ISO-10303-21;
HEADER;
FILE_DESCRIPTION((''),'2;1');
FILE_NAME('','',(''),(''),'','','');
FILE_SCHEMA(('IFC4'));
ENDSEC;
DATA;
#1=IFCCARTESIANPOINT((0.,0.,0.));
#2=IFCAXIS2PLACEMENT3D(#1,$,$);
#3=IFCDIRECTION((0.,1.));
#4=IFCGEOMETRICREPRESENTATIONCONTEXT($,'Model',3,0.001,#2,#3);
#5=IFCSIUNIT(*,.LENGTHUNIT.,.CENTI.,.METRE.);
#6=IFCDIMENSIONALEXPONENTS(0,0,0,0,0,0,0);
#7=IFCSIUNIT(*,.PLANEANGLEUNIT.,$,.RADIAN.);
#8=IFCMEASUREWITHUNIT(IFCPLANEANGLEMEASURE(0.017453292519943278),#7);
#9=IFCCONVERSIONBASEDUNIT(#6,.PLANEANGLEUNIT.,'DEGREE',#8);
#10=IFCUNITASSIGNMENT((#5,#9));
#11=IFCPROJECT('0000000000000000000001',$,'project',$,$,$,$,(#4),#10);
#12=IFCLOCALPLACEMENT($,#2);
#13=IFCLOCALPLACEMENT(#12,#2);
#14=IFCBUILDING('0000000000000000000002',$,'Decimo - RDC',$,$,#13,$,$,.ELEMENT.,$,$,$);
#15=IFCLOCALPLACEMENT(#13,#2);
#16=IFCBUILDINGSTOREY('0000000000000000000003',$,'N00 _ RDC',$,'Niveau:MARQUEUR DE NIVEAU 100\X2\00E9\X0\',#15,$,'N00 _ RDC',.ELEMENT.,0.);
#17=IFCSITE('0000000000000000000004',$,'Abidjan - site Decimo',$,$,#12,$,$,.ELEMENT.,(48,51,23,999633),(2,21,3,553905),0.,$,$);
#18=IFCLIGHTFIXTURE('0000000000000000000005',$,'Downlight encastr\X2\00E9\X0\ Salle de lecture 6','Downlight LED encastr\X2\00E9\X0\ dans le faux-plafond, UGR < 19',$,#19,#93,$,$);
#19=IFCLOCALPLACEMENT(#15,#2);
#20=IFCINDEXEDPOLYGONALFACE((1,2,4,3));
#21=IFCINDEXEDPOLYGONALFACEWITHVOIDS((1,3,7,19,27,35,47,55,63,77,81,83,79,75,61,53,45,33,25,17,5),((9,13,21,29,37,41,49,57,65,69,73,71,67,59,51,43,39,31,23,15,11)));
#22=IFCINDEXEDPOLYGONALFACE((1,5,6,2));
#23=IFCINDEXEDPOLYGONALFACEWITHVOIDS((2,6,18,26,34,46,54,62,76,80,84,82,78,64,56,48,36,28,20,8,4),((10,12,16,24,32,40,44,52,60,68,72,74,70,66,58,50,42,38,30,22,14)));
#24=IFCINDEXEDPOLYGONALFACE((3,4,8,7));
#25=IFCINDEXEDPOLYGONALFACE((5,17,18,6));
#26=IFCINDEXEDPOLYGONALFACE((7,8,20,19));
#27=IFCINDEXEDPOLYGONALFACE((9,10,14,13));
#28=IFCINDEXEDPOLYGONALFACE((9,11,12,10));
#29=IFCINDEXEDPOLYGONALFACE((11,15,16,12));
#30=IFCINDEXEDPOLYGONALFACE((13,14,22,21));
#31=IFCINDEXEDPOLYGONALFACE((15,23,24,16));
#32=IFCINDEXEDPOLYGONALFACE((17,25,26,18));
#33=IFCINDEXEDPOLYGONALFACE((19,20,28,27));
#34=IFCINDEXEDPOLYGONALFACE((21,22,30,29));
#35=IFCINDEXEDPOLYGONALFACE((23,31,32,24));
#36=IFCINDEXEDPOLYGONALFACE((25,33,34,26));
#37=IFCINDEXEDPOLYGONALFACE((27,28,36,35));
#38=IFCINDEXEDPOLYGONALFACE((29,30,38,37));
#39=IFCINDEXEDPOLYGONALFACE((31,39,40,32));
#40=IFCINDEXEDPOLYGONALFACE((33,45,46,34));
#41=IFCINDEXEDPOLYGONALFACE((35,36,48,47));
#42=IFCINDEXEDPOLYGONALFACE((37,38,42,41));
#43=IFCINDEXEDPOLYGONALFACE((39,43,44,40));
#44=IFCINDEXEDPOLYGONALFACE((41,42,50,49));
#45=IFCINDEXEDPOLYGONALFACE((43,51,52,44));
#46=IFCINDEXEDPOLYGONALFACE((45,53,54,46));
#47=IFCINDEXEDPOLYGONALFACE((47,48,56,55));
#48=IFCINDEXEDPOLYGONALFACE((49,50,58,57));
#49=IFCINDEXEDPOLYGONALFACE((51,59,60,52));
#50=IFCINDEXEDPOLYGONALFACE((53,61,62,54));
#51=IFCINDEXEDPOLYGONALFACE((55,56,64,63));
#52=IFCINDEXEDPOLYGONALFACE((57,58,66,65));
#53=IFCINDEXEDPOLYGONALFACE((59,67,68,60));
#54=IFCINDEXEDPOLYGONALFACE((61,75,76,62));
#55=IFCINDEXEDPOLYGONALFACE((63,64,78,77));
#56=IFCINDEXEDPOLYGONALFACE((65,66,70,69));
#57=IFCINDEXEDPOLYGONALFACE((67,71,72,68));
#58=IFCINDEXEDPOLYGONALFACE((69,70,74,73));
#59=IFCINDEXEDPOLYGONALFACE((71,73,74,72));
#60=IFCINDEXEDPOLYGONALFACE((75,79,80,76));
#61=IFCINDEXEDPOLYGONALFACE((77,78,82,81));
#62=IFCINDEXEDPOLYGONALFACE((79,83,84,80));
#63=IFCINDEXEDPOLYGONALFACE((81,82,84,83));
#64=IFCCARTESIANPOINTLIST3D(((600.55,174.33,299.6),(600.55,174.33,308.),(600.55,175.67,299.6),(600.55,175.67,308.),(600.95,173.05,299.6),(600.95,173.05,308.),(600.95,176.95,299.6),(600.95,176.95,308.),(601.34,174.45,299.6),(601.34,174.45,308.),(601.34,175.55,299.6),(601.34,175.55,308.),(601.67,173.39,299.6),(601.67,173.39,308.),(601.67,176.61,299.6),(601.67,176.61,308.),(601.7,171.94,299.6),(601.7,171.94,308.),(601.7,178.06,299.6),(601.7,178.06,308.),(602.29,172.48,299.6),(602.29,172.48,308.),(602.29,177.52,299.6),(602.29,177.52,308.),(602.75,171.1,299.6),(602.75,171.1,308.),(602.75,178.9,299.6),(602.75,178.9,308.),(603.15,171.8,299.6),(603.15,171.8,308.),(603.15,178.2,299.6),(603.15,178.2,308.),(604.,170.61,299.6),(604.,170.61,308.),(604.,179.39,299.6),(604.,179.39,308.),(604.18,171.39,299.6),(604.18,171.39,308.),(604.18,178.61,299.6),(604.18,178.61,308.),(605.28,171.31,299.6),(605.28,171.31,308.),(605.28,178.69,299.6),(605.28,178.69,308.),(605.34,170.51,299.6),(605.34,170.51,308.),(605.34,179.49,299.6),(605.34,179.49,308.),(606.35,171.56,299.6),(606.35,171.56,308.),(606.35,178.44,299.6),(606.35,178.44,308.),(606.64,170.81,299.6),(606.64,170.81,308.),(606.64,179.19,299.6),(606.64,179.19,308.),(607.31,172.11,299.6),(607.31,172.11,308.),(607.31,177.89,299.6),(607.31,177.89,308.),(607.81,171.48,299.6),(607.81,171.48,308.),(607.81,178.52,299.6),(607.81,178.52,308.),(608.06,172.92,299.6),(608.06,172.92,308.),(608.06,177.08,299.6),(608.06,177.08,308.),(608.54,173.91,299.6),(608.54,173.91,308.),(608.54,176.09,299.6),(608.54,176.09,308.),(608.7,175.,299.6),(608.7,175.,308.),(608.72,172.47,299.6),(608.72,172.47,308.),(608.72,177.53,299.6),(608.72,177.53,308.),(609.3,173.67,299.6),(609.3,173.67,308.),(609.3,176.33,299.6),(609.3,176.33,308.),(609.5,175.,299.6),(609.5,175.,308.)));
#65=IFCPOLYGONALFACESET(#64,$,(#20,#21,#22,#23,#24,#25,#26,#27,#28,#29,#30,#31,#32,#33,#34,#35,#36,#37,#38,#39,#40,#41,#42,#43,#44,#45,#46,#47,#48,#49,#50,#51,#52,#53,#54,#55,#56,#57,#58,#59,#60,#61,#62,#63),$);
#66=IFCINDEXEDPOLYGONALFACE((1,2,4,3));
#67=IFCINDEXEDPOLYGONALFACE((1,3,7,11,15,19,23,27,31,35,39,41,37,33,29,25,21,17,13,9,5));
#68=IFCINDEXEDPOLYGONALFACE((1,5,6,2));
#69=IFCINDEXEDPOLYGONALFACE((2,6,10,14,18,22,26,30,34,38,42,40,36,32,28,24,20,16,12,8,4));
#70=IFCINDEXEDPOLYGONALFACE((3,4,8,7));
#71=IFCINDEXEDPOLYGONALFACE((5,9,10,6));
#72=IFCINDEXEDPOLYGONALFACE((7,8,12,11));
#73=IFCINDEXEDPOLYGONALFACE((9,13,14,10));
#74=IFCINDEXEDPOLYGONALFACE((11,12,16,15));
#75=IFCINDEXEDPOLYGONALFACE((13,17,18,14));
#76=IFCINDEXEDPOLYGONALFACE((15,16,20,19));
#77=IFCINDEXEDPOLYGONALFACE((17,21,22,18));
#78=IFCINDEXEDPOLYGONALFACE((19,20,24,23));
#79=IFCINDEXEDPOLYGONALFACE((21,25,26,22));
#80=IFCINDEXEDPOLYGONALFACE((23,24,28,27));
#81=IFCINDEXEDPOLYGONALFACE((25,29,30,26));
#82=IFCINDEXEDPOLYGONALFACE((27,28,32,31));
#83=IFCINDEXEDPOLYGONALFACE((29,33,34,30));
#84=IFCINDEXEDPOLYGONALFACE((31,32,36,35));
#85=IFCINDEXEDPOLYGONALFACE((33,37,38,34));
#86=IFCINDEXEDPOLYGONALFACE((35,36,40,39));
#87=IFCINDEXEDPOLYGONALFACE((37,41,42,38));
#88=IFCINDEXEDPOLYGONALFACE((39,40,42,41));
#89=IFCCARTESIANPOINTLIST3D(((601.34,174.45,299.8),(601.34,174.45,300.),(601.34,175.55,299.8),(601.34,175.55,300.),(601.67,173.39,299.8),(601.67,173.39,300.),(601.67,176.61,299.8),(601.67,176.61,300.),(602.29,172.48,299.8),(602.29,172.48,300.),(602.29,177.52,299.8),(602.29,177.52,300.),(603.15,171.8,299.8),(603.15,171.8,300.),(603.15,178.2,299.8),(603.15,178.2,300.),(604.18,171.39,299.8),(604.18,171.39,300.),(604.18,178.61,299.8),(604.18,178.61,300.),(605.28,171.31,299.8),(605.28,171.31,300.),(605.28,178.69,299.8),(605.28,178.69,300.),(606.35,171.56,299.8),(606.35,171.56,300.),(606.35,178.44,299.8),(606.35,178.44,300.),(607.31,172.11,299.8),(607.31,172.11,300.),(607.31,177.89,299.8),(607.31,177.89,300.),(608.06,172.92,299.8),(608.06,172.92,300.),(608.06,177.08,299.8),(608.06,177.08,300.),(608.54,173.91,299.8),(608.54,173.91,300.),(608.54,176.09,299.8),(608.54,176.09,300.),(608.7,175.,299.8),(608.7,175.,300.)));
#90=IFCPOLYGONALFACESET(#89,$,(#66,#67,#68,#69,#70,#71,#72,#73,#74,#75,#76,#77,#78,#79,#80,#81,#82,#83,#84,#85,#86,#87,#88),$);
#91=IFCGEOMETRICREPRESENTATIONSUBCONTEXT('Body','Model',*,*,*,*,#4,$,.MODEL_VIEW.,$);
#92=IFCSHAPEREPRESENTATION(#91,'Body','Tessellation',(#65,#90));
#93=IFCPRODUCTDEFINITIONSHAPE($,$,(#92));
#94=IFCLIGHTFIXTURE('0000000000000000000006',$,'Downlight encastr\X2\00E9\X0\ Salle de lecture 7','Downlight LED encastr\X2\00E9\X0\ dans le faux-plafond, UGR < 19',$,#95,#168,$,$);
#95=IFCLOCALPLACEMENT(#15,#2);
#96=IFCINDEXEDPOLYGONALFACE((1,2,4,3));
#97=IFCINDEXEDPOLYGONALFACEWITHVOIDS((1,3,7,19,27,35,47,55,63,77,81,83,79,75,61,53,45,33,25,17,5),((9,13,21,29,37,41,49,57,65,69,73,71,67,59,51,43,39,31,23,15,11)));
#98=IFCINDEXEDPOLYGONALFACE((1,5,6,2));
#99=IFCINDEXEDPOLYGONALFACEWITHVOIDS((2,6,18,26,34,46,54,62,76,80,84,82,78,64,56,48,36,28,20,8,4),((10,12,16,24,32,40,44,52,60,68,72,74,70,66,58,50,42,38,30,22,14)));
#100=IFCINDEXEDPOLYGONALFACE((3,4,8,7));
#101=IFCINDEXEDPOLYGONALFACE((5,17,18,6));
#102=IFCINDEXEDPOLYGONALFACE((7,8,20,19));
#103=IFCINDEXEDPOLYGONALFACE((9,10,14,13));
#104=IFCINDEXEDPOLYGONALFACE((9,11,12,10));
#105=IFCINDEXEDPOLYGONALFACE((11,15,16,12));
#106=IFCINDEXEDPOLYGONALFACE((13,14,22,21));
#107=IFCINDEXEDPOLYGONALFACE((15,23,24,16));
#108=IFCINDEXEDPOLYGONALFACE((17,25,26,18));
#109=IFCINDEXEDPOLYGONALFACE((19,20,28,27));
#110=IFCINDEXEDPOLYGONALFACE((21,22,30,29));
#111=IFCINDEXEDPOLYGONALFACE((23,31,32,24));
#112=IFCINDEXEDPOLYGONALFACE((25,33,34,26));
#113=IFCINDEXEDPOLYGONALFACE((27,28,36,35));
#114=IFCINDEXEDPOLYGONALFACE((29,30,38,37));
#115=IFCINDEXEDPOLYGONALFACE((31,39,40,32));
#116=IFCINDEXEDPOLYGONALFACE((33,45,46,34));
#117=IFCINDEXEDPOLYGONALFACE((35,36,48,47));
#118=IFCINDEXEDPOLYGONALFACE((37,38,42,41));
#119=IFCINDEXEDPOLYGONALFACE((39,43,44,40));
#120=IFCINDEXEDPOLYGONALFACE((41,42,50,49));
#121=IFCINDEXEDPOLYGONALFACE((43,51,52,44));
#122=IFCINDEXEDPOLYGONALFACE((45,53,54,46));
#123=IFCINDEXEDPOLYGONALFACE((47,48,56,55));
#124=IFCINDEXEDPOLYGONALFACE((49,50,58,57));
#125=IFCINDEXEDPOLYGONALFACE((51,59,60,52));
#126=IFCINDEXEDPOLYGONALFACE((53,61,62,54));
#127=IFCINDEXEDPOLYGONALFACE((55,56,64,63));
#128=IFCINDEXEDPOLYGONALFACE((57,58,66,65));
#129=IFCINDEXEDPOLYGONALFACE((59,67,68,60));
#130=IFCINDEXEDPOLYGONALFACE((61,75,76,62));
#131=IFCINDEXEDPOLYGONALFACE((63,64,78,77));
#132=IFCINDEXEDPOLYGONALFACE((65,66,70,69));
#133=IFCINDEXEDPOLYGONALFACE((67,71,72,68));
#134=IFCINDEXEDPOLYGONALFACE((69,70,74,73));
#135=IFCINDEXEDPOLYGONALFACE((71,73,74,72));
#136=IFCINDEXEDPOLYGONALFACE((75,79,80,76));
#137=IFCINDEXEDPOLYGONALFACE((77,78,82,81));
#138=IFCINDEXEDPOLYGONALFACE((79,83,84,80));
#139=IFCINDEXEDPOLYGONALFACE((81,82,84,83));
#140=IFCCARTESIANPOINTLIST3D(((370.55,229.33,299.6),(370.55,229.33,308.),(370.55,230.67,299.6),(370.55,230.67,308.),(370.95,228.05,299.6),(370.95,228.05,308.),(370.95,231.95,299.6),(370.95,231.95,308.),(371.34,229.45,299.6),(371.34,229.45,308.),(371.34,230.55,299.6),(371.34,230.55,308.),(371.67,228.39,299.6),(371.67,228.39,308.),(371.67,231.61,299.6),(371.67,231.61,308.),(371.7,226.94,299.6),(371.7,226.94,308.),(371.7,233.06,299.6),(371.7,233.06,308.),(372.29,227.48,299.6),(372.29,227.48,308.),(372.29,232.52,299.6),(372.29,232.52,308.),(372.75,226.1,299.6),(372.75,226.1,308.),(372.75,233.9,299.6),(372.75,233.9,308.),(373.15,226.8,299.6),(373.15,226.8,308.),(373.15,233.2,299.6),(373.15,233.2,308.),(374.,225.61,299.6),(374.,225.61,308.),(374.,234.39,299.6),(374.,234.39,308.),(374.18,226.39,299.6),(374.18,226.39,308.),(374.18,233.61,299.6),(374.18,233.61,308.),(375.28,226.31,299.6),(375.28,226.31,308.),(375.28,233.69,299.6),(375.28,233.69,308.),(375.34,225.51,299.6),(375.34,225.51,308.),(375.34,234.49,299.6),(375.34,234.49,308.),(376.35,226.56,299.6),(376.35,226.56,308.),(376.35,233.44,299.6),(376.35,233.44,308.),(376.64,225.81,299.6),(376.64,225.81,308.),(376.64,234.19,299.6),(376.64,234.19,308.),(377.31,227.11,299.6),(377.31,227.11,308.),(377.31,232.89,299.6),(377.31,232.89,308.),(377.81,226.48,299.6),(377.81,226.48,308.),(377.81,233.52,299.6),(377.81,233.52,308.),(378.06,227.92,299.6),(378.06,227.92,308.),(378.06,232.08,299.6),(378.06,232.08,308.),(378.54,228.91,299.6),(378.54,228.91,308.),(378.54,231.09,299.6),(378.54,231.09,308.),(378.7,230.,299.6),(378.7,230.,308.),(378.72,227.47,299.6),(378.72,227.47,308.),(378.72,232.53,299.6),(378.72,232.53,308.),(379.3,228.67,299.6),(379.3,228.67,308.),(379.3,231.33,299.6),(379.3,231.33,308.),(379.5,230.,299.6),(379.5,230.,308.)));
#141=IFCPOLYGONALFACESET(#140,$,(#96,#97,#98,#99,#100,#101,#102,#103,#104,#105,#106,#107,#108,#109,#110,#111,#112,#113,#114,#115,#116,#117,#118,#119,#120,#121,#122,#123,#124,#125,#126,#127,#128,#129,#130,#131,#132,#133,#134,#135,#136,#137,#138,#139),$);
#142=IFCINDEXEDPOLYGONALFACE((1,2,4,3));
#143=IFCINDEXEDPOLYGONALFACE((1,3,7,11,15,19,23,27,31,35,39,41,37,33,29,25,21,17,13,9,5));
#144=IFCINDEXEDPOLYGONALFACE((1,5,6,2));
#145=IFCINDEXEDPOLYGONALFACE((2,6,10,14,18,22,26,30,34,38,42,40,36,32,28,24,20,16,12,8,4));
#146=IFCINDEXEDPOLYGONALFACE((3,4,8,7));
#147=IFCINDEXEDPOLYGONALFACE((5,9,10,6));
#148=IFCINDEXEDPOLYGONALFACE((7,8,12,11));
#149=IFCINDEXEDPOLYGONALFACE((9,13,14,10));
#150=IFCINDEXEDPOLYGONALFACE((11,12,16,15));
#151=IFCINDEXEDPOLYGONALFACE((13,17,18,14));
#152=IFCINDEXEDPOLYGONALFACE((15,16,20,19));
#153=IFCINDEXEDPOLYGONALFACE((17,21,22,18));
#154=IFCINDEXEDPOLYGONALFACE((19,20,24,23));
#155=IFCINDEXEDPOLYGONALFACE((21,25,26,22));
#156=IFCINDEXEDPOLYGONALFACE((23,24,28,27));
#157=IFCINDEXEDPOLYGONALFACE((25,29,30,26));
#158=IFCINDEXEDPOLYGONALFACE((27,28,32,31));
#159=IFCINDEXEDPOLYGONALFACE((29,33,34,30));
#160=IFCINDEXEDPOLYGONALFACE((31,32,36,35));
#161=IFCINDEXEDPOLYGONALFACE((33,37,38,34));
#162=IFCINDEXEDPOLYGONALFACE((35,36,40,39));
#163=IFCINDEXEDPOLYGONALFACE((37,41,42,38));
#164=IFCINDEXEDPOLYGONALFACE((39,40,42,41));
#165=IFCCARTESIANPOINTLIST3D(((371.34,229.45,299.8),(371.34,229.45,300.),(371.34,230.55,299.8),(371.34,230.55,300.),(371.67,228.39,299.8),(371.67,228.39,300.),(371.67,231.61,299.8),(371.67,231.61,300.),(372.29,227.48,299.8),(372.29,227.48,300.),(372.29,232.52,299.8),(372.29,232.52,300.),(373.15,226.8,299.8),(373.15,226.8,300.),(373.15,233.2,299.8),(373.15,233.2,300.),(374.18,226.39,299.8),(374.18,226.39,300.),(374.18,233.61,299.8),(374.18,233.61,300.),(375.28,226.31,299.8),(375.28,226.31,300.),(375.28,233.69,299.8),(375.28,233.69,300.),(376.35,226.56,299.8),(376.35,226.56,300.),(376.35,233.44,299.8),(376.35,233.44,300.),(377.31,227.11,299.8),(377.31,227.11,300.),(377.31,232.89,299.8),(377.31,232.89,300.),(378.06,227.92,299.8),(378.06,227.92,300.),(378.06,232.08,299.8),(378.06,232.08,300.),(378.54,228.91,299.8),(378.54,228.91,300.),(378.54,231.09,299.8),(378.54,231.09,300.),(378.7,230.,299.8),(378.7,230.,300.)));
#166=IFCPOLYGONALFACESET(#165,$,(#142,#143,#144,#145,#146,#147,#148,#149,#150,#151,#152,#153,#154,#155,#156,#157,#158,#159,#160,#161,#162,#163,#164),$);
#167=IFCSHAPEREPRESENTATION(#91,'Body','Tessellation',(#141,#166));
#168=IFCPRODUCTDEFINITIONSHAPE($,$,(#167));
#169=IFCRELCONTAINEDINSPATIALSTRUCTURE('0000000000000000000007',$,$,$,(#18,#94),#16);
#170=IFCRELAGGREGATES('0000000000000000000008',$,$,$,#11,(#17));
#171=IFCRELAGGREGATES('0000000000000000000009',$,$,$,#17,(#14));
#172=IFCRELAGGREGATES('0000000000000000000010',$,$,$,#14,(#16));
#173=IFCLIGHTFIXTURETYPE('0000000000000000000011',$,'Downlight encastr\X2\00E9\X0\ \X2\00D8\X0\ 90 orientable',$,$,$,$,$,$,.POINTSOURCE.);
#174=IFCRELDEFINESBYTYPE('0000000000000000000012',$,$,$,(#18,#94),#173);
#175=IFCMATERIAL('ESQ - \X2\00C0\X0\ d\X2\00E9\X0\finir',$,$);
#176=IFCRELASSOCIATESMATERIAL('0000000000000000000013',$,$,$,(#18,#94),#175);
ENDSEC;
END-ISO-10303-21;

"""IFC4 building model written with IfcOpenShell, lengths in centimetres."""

from ifc_helpers import new_model, entity, si_unit, converted_unit, direction, frame, frame_2d, origin, origin_with_axes, place, context, subcontext, project, spatial, circle, hollow_circle, extrude, material, type_object, element, save


model = new_model("IFC4")

# Units and contexts
model_context = context("Model", 3, precision=0.001, world=origin(), true_north=direction((0.0, 1.0)))
body_context = subcontext(model_context, "Body", "Model", "MODEL_VIEW")
ifc_project = project(units=[si_unit("LENGTHUNIT", "METRE", prefix="CENTI"), converted_unit("PLANEANGLEUNIT", "DEGREE", entity("IfcPlaneAngleMeasure", 0.017453292519943278), si_unit("PLANEANGLEUNIT", "RADIAN"), dimensions=[0, 0, 0, 0, 0, 0, 0])], contexts=[model_context])

# Site, building, storey
site_placement = place(None, origin())
site = spatial("IfcSite", under=ifc_project, at=site_placement, Name="Abidjan - site Decimo", CompositionType="ELEMENT", RefLatitude=(48, 51, 23, 999633), RefLongitude=(2, 21, 3, 553905), RefElevation=0.0)
building_placement = place(site_placement, origin())
building = spatial("IfcBuilding", under=site, at=building_placement, Name="Decimo - RDC", CompositionType="ELEMENT")
storey_placement = place(building_placement, origin())
storey = spatial("IfcBuildingStorey", under=building, at=storey_placement, Name="N00 _ RDC", ObjectType="Niveau:MARQUEUR DE NIVEAU 100é", LongName="N00 _ RDC", CompositionType="ELEMENT", Elevation=0.0)

# Light fixtures
ifc_material_1 = material(Name="ESQ - À définir")
light_fixture_type_1 = type_object("IfcLightFixtureType", Name="Downlight encastré Ø 90 orientable", PredefinedType="POINTSOURCE")
light_fixture_1_placement = place(storey_placement, origin_with_axes())
element("IfcLightFixture", 1, at=light_fixture_1_placement, inside=storey, type_object=light_fixture_type_1, material=ifc_material_1, Name="Downlight encastré Salle de lecture 6", Description="Downlight LED encastré dans le faux-plafond, UGR < 19", context=body_context, shape_type="SweptSolid", body=[
    extrude(hollow_circle(Radius=4.5, WallThickness=0.8, at=frame_2d((605.0, 175.0))), frame((0.0, 0.0, 299.6)), (0.0, 0.0, 1.0), 8.4),
    extrude(circle(Radius=3.7, at=frame_2d((605.0, 175.0))), frame((0.0, 0.0, 299.8)), (0.0, 0.0, 1.0), 0.2),
])
light_fixture_2_placement = place(storey_placement, origin_with_axes())
element("IfcLightFixture", 2, at=light_fixture_2_placement, inside=storey, type_object=light_fixture_type_1, material=ifc_material_1, Name="Downlight encastré Salle de lecture 7", Description="Downlight LED encastré dans le faux-plafond, UGR < 19", context=body_context, shape_type="SweptSolid", body=[
    extrude(hollow_circle(Radius=4.5, WallThickness=0.8, at=frame_2d((375.0, 230.0))), frame((0.0, 0.0, 299.6)), (0.0, 0.0, 1.0), 8.4),
    extrude(circle(Radius=3.7, at=frame_2d((375.0, 230.0))), frame((0.0, 0.0, 299.8)), (0.0, 0.0, 1.0), 0.2),
])

save(model, "model.ifc")
